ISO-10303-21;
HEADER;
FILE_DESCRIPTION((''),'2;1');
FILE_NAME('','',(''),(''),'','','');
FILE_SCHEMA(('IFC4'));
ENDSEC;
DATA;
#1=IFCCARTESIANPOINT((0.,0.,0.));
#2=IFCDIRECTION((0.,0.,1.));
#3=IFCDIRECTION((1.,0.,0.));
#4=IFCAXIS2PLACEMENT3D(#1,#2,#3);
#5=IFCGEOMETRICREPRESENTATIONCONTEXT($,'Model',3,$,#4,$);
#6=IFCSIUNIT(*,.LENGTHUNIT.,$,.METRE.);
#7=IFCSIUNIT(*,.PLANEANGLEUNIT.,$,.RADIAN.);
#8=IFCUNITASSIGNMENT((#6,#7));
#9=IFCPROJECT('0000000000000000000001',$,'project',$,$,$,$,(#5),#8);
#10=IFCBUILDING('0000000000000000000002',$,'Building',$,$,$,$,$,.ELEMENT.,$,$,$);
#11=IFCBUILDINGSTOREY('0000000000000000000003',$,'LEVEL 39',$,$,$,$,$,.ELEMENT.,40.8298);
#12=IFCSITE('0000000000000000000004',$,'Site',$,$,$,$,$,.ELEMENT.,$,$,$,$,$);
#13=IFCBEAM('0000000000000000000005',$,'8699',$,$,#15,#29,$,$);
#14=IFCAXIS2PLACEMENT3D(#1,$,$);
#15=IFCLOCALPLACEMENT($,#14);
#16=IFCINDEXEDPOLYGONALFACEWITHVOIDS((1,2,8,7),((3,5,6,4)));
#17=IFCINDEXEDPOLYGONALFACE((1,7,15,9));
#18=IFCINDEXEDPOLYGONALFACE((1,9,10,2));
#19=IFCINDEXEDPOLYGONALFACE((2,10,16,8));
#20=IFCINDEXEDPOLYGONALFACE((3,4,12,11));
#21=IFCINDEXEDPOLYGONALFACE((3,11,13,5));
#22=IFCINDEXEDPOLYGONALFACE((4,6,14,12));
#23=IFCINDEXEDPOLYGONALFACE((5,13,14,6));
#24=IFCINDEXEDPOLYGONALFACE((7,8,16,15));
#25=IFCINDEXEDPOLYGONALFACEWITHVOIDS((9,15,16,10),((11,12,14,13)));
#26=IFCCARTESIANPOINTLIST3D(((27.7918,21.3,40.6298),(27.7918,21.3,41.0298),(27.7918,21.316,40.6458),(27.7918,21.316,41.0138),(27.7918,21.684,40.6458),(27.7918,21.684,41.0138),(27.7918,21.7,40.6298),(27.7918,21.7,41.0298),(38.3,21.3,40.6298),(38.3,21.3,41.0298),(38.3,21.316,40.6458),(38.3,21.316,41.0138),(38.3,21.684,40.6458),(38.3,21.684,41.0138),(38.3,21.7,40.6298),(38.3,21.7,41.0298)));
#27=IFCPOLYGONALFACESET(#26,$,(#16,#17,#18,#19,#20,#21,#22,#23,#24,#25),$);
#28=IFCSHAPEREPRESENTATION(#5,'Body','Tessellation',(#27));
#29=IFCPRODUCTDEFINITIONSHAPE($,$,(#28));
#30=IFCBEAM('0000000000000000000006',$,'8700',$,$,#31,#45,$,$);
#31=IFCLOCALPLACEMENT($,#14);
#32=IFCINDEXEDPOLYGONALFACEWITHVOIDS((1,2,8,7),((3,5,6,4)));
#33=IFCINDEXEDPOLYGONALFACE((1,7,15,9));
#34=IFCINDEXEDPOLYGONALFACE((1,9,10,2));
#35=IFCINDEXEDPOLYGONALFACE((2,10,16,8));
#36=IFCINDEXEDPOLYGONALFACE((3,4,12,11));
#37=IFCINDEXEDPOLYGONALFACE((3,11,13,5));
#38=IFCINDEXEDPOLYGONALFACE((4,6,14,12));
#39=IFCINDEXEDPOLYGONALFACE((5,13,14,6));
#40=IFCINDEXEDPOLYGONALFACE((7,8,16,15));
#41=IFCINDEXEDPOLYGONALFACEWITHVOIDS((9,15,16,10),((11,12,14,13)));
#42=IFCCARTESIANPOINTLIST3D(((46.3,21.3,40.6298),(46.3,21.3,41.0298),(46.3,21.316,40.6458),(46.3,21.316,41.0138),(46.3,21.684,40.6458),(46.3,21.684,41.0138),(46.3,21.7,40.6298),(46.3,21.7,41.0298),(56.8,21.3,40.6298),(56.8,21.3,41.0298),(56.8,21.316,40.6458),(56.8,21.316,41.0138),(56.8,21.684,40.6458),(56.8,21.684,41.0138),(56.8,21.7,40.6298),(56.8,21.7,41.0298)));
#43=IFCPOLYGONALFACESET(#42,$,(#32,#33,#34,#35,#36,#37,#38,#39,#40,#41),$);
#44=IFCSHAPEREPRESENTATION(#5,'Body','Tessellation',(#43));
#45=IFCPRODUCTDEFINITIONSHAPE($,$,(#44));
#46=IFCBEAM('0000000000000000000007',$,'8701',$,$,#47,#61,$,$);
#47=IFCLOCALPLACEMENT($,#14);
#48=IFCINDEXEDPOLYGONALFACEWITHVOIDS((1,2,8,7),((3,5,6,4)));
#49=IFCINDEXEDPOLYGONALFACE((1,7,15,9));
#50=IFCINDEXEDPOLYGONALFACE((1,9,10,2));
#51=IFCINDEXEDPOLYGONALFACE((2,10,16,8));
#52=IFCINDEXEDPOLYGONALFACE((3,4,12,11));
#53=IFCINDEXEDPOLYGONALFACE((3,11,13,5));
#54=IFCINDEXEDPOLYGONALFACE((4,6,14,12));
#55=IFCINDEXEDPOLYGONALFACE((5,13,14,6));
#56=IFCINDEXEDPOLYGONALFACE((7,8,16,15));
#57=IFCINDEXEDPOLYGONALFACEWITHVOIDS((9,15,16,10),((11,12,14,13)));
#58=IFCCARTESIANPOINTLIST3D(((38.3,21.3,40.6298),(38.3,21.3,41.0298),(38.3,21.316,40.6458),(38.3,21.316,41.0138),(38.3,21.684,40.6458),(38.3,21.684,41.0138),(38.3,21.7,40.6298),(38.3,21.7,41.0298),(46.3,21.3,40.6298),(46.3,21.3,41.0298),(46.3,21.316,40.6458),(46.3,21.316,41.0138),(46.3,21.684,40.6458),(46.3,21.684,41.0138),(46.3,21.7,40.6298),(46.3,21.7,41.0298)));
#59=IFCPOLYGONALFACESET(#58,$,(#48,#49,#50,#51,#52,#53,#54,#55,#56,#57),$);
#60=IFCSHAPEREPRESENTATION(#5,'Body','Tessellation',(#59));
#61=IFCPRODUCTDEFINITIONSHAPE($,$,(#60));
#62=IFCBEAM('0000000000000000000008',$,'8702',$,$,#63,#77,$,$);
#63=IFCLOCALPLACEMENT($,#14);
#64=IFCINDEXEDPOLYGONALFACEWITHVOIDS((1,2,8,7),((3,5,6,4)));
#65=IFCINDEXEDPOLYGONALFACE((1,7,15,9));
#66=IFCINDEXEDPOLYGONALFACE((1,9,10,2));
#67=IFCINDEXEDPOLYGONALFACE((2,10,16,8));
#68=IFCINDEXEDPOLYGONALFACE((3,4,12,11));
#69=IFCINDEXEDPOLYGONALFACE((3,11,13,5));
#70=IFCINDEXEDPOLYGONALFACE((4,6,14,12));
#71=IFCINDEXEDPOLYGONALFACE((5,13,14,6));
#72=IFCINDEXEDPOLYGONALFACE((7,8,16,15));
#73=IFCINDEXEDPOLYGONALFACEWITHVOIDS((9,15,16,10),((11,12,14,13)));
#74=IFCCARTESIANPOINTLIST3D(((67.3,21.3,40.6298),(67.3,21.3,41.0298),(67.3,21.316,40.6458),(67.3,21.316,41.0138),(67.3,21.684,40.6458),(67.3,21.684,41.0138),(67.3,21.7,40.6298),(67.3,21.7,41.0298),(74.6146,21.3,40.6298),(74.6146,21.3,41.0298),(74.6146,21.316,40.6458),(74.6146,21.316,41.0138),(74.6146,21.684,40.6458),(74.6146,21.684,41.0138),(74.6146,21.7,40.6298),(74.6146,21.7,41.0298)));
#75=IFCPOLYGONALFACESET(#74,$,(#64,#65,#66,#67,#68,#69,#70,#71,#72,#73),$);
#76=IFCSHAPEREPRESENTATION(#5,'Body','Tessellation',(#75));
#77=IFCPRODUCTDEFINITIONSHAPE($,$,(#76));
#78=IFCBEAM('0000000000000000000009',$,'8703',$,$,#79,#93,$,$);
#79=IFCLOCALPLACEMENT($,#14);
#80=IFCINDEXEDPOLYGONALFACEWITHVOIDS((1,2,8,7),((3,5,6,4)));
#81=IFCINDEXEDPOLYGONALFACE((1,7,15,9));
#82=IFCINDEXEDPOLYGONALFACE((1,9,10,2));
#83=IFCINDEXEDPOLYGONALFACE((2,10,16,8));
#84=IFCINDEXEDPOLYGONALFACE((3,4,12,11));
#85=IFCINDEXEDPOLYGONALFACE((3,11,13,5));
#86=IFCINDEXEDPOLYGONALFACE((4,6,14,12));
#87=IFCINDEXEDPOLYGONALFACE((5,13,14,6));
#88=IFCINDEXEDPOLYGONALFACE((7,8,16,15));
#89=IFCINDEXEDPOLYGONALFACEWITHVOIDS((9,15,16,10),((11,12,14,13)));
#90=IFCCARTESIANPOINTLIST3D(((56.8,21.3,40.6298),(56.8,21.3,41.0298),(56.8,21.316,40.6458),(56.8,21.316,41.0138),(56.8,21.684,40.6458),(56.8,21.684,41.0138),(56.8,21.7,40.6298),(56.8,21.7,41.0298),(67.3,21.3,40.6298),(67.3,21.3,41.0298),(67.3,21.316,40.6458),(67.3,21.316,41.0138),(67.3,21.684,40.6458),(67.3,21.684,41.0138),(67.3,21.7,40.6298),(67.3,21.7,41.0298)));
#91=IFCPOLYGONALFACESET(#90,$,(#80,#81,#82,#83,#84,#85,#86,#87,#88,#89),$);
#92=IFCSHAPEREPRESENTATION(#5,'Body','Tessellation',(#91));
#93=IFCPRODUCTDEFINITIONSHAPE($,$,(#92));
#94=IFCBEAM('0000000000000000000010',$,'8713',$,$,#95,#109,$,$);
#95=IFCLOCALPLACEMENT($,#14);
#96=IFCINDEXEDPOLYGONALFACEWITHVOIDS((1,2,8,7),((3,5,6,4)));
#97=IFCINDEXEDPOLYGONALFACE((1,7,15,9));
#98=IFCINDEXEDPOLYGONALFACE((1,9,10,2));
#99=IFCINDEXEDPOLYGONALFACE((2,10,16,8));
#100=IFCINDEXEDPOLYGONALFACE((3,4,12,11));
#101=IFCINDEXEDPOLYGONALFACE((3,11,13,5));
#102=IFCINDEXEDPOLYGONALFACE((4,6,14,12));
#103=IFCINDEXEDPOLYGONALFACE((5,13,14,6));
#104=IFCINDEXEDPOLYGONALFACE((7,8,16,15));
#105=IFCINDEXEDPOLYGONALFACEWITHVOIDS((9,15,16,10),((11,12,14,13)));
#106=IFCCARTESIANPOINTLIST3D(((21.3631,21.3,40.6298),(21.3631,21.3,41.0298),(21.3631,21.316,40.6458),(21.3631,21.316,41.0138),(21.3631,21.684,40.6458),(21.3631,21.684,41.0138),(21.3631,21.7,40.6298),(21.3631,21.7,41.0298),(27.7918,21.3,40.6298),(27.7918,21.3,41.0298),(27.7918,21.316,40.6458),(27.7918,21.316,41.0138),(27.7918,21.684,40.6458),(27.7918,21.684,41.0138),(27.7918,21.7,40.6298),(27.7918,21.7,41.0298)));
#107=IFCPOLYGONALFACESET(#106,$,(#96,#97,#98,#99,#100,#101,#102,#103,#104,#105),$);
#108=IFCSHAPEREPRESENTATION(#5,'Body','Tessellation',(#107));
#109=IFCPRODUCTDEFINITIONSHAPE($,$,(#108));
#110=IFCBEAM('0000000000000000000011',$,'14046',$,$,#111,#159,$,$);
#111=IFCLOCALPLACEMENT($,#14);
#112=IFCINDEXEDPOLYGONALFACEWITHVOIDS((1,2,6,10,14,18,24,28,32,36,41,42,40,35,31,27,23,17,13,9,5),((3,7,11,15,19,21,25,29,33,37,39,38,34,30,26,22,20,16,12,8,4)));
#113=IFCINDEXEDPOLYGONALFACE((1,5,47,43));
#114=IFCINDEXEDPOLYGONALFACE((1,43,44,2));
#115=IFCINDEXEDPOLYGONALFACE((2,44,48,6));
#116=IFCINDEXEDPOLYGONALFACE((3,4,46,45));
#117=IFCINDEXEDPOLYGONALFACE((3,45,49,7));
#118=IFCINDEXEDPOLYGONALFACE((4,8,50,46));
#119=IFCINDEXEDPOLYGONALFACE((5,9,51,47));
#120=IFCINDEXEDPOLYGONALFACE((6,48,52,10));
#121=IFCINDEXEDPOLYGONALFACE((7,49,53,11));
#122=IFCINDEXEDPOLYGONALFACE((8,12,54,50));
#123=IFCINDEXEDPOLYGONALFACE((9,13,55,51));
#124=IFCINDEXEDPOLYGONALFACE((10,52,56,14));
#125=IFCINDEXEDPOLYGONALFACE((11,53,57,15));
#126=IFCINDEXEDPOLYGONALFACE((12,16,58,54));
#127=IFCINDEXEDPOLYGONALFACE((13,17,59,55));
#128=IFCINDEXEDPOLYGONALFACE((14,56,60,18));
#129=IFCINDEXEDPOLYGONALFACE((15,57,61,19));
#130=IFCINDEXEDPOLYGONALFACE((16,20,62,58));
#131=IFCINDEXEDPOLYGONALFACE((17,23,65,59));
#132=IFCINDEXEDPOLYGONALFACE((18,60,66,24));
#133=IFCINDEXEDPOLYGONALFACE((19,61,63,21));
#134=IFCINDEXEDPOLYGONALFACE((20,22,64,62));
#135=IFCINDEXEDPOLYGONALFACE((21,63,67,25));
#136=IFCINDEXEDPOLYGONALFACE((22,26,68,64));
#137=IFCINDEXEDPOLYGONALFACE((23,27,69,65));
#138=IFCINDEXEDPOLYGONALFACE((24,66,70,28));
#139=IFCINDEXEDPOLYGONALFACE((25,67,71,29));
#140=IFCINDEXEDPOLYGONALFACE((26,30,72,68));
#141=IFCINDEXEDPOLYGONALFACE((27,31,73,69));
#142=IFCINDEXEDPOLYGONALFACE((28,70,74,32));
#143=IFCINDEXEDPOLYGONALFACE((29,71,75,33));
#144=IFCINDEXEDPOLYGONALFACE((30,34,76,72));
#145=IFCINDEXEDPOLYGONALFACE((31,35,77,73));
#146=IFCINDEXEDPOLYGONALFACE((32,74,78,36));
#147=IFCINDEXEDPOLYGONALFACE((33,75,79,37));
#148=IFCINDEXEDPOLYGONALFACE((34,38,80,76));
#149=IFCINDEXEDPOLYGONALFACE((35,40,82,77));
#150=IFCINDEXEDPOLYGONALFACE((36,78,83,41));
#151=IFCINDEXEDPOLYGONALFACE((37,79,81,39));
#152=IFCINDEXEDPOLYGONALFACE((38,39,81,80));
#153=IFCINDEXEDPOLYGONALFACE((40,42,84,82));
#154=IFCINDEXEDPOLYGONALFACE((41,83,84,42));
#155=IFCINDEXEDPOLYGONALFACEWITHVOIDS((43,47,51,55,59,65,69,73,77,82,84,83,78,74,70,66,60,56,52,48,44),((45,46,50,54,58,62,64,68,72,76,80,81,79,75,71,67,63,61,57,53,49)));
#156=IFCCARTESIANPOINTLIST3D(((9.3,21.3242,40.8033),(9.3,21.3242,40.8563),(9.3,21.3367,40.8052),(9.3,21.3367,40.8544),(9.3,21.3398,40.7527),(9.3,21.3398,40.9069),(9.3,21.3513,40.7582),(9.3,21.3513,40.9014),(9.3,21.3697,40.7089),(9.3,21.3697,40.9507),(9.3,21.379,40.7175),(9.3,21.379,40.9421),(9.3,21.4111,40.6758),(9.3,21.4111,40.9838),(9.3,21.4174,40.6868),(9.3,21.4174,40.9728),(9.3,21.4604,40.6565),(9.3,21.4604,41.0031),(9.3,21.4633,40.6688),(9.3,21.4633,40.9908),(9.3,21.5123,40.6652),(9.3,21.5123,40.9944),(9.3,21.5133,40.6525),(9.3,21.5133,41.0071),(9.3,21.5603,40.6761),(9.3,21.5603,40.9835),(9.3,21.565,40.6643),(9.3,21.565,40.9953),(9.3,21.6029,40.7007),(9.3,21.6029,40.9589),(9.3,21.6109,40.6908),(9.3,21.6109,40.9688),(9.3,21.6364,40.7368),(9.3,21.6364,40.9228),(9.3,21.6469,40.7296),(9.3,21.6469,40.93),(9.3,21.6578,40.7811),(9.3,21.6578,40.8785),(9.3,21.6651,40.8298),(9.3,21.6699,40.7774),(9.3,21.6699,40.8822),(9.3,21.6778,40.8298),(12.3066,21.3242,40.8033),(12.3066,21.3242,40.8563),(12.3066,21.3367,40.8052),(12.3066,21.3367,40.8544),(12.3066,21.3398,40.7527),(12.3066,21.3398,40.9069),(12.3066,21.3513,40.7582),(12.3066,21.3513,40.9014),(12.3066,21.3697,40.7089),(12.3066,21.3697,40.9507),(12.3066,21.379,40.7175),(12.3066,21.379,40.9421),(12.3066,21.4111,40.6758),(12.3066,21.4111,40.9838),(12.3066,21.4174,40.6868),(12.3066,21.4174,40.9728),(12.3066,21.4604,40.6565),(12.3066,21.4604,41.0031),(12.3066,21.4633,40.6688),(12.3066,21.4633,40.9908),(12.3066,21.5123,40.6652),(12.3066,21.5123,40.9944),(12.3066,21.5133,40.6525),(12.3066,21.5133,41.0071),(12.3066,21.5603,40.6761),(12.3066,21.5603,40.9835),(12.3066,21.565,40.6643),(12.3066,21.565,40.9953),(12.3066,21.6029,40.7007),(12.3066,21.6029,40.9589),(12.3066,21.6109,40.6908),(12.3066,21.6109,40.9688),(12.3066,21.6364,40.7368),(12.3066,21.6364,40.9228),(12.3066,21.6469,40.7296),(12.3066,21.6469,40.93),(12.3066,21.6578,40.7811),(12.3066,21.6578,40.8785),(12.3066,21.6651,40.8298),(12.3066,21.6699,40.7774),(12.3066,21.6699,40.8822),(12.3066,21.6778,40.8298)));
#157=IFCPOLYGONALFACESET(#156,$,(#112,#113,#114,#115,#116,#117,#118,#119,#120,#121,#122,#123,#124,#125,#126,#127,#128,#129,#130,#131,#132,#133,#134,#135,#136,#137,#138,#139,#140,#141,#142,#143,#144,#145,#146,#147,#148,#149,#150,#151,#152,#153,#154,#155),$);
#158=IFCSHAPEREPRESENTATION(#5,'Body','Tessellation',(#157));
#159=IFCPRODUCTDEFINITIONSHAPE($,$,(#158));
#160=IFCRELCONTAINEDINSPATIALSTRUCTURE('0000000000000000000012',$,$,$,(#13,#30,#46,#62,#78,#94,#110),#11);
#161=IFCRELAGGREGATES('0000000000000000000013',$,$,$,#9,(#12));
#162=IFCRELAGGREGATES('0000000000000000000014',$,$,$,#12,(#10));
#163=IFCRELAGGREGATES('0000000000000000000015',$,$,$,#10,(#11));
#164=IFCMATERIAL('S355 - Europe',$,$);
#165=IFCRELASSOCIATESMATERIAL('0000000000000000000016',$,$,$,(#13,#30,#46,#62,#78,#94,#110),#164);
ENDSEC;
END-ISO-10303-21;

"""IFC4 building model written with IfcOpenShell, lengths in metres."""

from ifc_helpers import new_model, si_unit, frame, origin_with_axes, origin_2d_with_axis, place, context, project, spatial, hollow_rectangle, hollow_circle, extrude, material, material_profile, profile_set, profile_usage, element, save


model = new_model("IFC4")

# Units and contexts
model_context = context("Model", 3, world=origin_with_axes())
ifc_project = project(units=[si_unit("LENGTHUNIT", "METRE"), si_unit("PLANEANGLEUNIT", "RADIAN")], contexts=[model_context])

# Site, building, storey
site = spatial("IfcSite", under=ifc_project, Name="Site", CompositionType="ELEMENT")
building = spatial("IfcBuilding", under=site, Name="Building", CompositionType="ELEMENT")
storey = spatial("IfcBuildingStorey", under=building, Name="LEVEL 39", CompositionType="ELEMENT", Elevation=40.8298)

# Beams
ifc_material = material(Name="S355 - Europe")
ifc_material_profile_1 = material_profile(ifc_material, hollow_rectangle(XDim=0.4, YDim=0.4, WallThickness=0.016, at=origin_2d_with_axis()))
ifc_profile_set_1 = profile_set([ifc_material_profile_1])
ifc_profile_usage_1 = profile_usage(ifc_profile_set_1, cardinal=10)
beam_1_placement = place(None, frame((27.7918, 21.5, 40.8298), z_axis=(1.0, 0.0, 0.0), x_axis=(0.0, 1.0, 0.0)))
element("IfcBeam", 1, at=beam_1_placement, inside=storey, material=ifc_profile_usage_1, Name="8699", context=model_context, shape_type="SweptSolid", body=[
    extrude(hollow_rectangle(XDim=0.4, YDim=0.4, WallThickness=0.016, at=origin_2d_with_axis()), origin_with_axes(), (0.0, 0.0, 1.0), 10.5082),
])
ifc_material_profile_2 = material_profile(ifc_material, hollow_rectangle(XDim=0.4, YDim=0.4, WallThickness=0.016, at=origin_2d_with_axis()))
ifc_profile_set_2 = profile_set([ifc_material_profile_2])
ifc_profile_usage_2 = profile_usage(ifc_profile_set_2, cardinal=10)
beam_2_placement = place(None, frame((46.3, 21.5, 40.8298), z_axis=(1.0, 0.0, 0.0), x_axis=(0.0, 1.0, 0.0)))
element("IfcBeam", 2, at=beam_2_placement, inside=storey, material=ifc_profile_usage_2, Name="8700", context=model_context, shape_type="SweptSolid", body=[
    extrude(hollow_rectangle(XDim=0.4, YDim=0.4, WallThickness=0.016, at=origin_2d_with_axis()), origin_with_axes(), (0.0, 0.0, 1.0), 10.5),
])
ifc_material_profile_3 = material_profile(ifc_material, hollow_rectangle(XDim=0.4, YDim=0.4, WallThickness=0.016, at=origin_2d_with_axis()))
ifc_profile_set_3 = profile_set([ifc_material_profile_3])
ifc_profile_usage_3 = profile_usage(ifc_profile_set_3, cardinal=10)
beam_3_placement = place(None, frame((38.3, 21.5, 40.8298), z_axis=(1.0, 0.0, 0.0), x_axis=(0.0, 1.0, 0.0)))
element("IfcBeam", 3, at=beam_3_placement, inside=storey, material=ifc_profile_usage_3, Name="8701", context=model_context, shape_type="SweptSolid", body=[
    extrude(hollow_rectangle(XDim=0.4, YDim=0.4, WallThickness=0.016, at=origin_2d_with_axis()), origin_with_axes(), (0.0, 0.0, 1.0), 8.0),
])
ifc_material_profile_4 = material_profile(ifc_material, hollow_rectangle(XDim=0.4, YDim=0.4, WallThickness=0.016, at=origin_2d_with_axis()))
ifc_profile_set_4 = profile_set([ifc_material_profile_4])
ifc_profile_usage_4 = profile_usage(ifc_profile_set_4, cardinal=10)
beam_4_placement = place(None, frame((67.3, 21.5, 40.8298), z_axis=(1.0, 0.0, 0.0), x_axis=(0.0, 1.0, 0.0)))
element("IfcBeam", 4, at=beam_4_placement, inside=storey, material=ifc_profile_usage_4, Name="8702", context=model_context, shape_type="SweptSolid", body=[
    extrude(hollow_rectangle(XDim=0.4, YDim=0.4, WallThickness=0.016, at=origin_2d_with_axis()), origin_with_axes(), (0.0, 0.0, 1.0), 7.3146),
])
ifc_material_profile_5 = material_profile(ifc_material, hollow_rectangle(XDim=0.4, YDim=0.4, WallThickness=0.016, at=origin_2d_with_axis()))
ifc_profile_set_5 = profile_set([ifc_material_profile_5])
ifc_profile_usage_5 = profile_usage(ifc_profile_set_5, cardinal=10)
beam_5_placement = place(None, frame((56.8, 21.5, 40.8298), z_axis=(1.0, 0.0, 0.0), x_axis=(0.0, 1.0, 0.0)))
element("IfcBeam", 5, at=beam_5_placement, inside=storey, material=ifc_profile_usage_5, Name="8703", context=model_context, shape_type="SweptSolid", body=[
    extrude(hollow_rectangle(XDim=0.4, YDim=0.4, WallThickness=0.016, at=origin_2d_with_axis()), origin_with_axes(), (0.0, 0.0, 1.0), 10.5),
])
ifc_material_profile_6 = material_profile(ifc_material, hollow_rectangle(XDim=0.4, YDim=0.4, WallThickness=0.016, at=origin_2d_with_axis()))
ifc_profile_set_6 = profile_set([ifc_material_profile_6])
ifc_profile_usage_6 = profile_usage(ifc_profile_set_6, cardinal=10)
beam_6_placement = place(None, frame((21.3631, 21.5, 40.8298), z_axis=(1.0, 0.0, 0.0), x_axis=(0.0, 1.0, 0.0)))
element("IfcBeam", 6, at=beam_6_placement, inside=storey, material=ifc_profile_usage_6, Name="8713", context=model_context, shape_type="SweptSolid", body=[
    extrude(hollow_rectangle(XDim=0.4, YDim=0.4, WallThickness=0.016, at=origin_2d_with_axis()), origin_with_axes(), (0.0, 0.0, 1.0), 6.4287),
])
ifc_material_profile_7 = material_profile(ifc_material, hollow_circle(Radius=0.1778, WallThickness=0.0127, at=origin_2d_with_axis()))
ifc_profile_set_7 = profile_set([ifc_material_profile_7])
ifc_profile_usage_7 = profile_usage(ifc_profile_set_7, cardinal=10)
beam_7_placement = place(None, frame((9.3, 21.5, 40.8298), z_axis=(1.0, 0.0, 0.0), x_axis=(0.0, 1.0, 0.0)))
element("IfcBeam", 7, at=beam_7_placement, inside=storey, material=ifc_profile_usage_7, Name="14046", context=model_context, shape_type="SweptSolid", body=[
    extrude(hollow_circle(Radius=0.1778, WallThickness=0.0127, at=origin_2d_with_axis()), origin_with_axes(), (0.0, 0.0, 1.0), 3.0066),
])

save(model, "model.ifc")
